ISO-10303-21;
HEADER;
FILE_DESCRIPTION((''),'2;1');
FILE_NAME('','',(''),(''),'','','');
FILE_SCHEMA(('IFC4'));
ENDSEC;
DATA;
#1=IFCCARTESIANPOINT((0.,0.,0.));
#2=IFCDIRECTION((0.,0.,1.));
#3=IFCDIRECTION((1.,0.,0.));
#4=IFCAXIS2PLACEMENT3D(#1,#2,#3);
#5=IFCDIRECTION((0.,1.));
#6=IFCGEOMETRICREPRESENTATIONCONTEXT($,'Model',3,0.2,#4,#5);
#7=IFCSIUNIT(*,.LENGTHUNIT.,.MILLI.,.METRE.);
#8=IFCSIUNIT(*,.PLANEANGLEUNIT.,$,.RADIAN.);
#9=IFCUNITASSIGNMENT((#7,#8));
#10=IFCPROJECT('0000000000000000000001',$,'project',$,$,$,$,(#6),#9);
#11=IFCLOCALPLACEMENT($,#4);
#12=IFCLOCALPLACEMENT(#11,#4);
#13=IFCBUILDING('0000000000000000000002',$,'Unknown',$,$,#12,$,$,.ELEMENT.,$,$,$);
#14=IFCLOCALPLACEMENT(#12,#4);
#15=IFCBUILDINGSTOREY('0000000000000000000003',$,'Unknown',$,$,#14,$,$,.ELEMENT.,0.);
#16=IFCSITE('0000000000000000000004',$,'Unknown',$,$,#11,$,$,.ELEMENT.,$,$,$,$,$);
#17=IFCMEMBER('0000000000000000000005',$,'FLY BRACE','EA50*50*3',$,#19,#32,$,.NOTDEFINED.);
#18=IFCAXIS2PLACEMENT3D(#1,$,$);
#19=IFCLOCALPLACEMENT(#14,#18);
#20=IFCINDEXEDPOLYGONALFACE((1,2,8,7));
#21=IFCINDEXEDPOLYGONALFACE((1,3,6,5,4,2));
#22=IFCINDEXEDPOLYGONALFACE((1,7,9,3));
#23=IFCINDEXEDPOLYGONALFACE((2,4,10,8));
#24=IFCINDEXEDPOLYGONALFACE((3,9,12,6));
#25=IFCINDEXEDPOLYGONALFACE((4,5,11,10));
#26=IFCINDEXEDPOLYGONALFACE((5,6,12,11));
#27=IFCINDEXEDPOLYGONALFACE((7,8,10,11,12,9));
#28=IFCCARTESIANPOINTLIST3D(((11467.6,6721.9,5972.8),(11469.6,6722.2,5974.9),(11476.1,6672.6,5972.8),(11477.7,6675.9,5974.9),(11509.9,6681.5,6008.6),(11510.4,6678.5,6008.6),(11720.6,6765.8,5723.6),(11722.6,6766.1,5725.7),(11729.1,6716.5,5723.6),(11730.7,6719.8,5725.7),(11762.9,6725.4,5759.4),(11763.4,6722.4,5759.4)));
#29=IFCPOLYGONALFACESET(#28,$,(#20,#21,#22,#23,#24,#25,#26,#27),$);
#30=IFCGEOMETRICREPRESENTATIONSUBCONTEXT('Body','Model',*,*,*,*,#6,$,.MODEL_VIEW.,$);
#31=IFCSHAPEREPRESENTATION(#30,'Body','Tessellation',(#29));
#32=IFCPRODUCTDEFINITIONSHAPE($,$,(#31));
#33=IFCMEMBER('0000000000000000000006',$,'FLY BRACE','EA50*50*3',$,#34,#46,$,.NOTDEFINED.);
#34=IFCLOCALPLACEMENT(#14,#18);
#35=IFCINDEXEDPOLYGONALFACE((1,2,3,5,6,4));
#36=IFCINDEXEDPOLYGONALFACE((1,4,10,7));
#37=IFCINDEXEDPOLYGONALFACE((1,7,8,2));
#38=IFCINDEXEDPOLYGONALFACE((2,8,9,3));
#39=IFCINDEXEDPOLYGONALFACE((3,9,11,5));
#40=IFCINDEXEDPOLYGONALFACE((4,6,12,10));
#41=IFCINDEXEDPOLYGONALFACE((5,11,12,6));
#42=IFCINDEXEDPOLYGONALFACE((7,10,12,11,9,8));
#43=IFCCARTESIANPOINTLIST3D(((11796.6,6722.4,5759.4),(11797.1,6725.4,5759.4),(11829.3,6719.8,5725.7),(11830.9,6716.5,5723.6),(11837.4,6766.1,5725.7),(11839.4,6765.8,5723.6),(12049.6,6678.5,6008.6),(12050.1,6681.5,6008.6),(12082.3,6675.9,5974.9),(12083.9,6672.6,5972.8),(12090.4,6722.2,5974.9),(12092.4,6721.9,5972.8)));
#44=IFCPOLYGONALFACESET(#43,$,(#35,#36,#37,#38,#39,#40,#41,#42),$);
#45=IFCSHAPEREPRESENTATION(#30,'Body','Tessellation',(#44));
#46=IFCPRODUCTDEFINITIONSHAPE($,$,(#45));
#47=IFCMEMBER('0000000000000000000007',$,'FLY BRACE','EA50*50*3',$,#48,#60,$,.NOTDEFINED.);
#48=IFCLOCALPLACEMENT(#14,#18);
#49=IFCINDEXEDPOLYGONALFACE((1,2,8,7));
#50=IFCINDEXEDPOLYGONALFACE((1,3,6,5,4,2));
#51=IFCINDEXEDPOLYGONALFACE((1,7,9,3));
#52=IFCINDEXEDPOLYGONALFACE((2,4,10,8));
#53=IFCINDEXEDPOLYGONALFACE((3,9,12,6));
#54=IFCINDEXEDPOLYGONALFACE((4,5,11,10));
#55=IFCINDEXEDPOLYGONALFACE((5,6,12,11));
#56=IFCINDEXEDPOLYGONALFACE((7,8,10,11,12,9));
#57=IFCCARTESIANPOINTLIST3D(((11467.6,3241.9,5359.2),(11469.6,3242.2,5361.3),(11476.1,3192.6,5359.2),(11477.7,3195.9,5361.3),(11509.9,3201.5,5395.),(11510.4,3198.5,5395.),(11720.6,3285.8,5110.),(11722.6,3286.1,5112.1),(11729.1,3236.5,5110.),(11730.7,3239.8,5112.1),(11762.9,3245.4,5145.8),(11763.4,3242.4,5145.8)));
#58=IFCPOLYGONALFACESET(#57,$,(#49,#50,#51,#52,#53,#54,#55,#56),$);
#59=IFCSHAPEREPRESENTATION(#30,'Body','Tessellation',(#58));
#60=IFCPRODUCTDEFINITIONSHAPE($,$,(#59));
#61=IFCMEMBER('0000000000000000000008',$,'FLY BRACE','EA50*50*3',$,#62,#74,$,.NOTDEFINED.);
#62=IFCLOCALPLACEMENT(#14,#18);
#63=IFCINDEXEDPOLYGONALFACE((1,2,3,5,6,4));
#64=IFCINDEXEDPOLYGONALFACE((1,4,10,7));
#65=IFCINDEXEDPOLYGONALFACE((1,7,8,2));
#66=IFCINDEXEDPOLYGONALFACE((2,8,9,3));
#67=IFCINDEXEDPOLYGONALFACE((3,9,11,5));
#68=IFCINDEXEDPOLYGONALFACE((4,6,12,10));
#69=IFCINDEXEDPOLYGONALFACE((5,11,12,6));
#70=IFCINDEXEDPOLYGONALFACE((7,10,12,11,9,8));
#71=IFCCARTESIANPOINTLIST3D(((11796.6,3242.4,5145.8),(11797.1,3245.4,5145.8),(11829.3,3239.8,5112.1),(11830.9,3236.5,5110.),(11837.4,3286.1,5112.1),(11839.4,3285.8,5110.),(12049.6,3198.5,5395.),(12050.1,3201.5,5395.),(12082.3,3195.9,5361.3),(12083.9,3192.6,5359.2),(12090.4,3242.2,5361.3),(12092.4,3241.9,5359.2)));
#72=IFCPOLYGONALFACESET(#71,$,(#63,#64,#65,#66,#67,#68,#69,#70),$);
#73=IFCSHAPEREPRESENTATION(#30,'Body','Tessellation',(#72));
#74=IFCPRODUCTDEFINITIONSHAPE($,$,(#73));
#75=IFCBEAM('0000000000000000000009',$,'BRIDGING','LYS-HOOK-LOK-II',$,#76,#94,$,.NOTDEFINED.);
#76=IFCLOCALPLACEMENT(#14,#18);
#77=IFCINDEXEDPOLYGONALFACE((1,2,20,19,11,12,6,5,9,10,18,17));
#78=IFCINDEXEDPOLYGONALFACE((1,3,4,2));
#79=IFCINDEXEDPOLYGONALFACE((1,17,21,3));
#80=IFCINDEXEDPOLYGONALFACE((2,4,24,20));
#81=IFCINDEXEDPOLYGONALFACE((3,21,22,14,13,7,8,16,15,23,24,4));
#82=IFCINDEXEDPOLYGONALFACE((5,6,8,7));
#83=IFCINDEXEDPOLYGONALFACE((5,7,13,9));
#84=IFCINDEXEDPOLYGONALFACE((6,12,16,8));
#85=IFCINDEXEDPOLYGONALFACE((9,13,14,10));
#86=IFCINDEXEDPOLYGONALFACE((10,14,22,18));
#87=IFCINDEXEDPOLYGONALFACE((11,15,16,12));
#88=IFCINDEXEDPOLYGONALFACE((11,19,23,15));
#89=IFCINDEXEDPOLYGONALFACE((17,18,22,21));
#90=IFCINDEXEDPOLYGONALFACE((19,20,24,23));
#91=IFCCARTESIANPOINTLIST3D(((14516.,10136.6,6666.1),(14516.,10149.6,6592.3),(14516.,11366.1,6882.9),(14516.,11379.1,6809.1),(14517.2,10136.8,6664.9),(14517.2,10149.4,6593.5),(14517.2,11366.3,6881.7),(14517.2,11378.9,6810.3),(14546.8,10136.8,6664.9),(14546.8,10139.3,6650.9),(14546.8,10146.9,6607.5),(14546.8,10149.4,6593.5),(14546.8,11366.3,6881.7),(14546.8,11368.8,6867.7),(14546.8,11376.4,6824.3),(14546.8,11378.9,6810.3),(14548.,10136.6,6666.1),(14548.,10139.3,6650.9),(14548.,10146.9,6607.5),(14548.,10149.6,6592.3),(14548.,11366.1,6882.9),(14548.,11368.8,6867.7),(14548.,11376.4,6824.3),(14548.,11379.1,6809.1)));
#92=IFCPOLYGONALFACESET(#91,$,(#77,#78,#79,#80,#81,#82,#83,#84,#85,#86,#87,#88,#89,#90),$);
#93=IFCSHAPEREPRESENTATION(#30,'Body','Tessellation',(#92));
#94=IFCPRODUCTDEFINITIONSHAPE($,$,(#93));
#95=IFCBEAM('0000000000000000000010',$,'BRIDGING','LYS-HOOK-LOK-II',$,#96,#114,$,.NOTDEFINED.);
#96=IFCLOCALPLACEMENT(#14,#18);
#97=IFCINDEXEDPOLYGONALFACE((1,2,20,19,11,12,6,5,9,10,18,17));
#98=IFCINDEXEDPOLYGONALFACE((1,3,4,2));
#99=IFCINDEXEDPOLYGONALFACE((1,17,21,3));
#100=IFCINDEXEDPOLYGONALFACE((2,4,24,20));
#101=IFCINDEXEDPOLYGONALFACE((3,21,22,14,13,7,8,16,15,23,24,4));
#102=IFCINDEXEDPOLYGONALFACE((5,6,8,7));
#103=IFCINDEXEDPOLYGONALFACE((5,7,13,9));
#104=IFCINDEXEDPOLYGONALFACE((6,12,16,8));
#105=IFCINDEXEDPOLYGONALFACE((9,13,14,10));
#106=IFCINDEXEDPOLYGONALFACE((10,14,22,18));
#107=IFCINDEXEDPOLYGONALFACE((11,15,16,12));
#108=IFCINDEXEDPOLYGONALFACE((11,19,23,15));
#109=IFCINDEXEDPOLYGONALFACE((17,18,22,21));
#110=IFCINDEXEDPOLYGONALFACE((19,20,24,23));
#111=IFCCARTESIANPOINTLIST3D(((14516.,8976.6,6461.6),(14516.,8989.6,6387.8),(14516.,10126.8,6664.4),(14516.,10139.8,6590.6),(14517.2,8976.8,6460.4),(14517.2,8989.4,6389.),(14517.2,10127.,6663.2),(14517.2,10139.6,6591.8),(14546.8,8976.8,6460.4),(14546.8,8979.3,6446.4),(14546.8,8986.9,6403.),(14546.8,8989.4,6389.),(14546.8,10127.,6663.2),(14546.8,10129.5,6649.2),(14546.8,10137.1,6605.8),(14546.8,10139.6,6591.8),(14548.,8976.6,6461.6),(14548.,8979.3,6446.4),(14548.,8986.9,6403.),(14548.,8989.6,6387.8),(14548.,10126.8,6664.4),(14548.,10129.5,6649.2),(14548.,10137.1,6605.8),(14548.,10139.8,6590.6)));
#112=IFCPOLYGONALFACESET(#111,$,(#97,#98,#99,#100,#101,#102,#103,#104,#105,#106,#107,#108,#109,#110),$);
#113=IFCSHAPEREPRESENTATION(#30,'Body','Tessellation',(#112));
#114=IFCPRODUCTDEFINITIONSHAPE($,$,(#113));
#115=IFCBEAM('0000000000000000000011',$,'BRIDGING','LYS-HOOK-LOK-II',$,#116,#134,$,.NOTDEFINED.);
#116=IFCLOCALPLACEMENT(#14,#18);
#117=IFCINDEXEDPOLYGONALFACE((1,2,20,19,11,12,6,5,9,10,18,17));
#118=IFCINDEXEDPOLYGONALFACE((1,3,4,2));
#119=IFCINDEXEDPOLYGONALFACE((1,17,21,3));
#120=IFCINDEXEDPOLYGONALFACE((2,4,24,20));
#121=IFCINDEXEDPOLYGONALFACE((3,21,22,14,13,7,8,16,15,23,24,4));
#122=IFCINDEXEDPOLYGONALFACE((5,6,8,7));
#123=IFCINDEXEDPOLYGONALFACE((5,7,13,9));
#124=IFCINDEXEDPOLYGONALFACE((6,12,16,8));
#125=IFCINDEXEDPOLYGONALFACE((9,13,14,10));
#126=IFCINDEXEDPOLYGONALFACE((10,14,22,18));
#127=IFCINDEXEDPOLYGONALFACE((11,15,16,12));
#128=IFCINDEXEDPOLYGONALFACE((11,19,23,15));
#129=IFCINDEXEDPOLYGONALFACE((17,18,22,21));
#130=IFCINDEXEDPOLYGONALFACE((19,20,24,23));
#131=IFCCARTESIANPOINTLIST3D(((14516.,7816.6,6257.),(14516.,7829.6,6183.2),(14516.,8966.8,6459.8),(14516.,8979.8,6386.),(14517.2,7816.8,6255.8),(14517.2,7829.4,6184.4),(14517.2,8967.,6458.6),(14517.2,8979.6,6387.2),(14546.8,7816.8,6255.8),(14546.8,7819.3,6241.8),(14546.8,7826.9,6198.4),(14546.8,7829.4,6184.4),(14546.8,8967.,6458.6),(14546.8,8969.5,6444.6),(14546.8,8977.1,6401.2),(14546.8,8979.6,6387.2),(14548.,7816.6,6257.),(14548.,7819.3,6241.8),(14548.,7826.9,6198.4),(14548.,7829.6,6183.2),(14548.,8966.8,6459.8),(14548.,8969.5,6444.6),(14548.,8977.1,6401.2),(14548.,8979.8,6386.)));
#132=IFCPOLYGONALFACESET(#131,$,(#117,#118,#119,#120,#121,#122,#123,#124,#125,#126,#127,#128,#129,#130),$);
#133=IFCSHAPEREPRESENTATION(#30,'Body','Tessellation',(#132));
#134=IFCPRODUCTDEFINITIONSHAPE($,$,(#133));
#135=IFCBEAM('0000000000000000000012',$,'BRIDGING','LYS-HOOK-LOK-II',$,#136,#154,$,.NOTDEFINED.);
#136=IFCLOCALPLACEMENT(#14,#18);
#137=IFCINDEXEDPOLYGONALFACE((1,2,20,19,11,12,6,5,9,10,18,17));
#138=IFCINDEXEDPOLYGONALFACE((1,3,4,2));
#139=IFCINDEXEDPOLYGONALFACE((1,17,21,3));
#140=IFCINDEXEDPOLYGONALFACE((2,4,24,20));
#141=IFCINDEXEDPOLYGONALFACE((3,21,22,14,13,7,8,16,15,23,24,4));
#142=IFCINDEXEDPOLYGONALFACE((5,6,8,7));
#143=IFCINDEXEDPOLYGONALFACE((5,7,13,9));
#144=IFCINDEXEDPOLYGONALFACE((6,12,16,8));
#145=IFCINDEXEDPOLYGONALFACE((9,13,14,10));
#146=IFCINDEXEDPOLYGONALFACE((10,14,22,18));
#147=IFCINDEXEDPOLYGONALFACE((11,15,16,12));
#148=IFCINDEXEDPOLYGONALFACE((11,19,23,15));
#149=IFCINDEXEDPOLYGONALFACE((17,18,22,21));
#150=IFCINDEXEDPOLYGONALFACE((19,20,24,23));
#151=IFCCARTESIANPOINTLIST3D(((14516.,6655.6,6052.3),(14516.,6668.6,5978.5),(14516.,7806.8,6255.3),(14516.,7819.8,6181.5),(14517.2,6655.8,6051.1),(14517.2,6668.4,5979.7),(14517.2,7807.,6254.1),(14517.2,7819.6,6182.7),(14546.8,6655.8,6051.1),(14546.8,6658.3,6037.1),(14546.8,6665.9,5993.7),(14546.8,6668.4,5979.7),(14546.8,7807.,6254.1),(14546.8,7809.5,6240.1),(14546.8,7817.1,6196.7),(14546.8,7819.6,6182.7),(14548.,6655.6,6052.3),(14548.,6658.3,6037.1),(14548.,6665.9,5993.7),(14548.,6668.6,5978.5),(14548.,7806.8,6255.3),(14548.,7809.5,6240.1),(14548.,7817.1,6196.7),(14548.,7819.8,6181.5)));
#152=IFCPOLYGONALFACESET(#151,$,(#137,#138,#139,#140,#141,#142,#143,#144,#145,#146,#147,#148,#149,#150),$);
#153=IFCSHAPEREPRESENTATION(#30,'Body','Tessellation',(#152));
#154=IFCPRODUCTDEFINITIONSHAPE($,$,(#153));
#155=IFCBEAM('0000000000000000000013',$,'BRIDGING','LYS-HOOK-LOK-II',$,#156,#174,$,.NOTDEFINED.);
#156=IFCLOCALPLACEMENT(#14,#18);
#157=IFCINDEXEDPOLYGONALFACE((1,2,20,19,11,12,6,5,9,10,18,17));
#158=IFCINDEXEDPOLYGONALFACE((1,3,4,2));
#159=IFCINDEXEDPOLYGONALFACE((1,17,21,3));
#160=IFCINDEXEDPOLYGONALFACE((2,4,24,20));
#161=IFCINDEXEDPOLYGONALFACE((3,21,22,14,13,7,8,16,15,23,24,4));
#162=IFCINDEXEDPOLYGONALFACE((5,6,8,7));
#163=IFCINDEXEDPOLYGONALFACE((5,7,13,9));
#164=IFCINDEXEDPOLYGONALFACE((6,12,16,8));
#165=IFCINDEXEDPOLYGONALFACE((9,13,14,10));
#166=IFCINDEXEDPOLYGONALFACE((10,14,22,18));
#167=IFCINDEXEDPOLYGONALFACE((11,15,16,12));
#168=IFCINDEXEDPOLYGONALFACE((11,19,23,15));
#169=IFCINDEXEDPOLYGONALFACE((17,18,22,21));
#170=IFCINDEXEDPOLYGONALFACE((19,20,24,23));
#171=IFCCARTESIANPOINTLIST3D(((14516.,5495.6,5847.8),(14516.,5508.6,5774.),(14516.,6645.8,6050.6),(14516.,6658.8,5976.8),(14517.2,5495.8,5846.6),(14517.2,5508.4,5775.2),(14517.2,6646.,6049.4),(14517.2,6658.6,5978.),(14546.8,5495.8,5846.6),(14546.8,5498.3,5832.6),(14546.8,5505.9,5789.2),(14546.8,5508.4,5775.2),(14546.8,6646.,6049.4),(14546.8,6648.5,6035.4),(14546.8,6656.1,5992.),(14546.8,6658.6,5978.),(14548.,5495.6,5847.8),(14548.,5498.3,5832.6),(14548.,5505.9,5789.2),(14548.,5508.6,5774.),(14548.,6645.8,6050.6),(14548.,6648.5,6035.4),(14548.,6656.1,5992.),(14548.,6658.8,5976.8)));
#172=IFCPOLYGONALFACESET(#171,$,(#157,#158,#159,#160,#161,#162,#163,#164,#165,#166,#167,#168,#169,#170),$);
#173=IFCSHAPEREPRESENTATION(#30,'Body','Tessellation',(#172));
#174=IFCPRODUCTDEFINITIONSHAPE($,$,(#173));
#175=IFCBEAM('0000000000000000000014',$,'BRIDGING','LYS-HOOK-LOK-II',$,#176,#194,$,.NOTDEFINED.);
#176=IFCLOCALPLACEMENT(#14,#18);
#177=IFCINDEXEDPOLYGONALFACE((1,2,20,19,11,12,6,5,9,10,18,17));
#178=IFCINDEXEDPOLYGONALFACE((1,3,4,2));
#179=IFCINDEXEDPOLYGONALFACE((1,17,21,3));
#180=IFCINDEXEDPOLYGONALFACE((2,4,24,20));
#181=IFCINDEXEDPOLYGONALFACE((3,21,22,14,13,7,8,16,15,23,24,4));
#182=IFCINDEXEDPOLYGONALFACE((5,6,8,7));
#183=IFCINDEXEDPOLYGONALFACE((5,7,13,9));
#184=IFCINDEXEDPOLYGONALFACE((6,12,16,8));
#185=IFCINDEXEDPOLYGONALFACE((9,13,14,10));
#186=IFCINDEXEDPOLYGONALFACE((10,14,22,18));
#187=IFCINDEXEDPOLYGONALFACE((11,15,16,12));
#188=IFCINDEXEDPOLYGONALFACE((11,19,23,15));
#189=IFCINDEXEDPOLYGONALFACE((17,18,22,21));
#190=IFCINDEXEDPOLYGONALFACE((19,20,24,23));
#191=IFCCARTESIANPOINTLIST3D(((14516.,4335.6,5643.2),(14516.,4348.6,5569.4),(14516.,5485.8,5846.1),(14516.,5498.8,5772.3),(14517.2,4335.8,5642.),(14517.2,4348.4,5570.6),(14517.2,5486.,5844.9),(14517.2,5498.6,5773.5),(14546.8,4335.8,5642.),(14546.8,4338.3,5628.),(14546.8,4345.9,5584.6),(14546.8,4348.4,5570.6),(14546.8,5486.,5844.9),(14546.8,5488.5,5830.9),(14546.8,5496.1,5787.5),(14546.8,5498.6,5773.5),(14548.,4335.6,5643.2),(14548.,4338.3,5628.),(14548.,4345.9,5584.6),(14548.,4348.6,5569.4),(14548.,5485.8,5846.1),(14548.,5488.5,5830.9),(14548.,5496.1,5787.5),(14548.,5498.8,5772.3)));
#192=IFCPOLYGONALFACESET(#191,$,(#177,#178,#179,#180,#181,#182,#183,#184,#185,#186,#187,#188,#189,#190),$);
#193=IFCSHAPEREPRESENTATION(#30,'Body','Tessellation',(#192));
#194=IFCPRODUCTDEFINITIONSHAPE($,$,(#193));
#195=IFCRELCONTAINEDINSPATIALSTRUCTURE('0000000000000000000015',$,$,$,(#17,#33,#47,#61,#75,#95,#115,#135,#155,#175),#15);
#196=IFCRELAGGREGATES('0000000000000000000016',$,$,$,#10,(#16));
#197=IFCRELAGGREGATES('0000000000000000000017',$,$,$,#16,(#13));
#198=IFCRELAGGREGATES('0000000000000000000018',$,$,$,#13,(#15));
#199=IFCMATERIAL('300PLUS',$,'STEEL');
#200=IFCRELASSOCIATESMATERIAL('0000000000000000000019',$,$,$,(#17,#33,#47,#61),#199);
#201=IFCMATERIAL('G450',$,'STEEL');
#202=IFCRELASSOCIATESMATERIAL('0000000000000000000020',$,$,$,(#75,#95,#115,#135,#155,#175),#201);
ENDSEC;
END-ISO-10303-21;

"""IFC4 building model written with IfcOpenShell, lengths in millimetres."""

from ifc_helpers import new_model, si_unit, direction, frame, origin_with_axes, place, context, subcontext, project, spatial, line, indexed_curve, outline, extrude, material, element, save


model = new_model("IFC4")

# Units and contexts
model_context = context("Model", 3, precision=0.2, world=origin_with_axes(), true_north=direction((0.0, 1.0)))
body_context = subcontext(model_context, "Body", "Model", "MODEL_VIEW")
ifc_project = project(units=[si_unit("LENGTHUNIT", "METRE", prefix="MILLI"), si_unit("PLANEANGLEUNIT", "RADIAN")], contexts=[model_context])

# Site, building, storey
site_placement = place(None, origin_with_axes())
site = spatial("IfcSite", under=ifc_project, at=site_placement, Name="Unknown", CompositionType="ELEMENT")
building_placement = place(site_placement, origin_with_axes())
building = spatial("IfcBuilding", under=site, at=building_placement, Name="Unknown", CompositionType="ELEMENT")
storey_placement = place(building_placement, origin_with_axes())
storey = spatial("IfcBuildingStorey", under=building, at=storey_placement, Name="Unknown", CompositionType="ELEMENT", Elevation=0.0)

# Members
ifc_material_1 = material(Name="300PLUS", Category="STEEL")
for number, where, z_axis, x_axis, name in (
    (1, (11489.0, 6700.2, 5990.7), (0.686182, 0.119065, 0.71762), (0.707055, 0.122687, -0.696435), "FLY BRACE"),
    (2, (12071.0, 6700.2, 5990.7), (0.170963, 0.985277, 0.0), (-0.707055, 0.122687, -0.696435), "FLY BRACE"),
    (3, (11489.0, 3220.2, 5377.1), (0.686182, 0.119065, 0.71762), (0.707055, 0.122687, -0.696435), "FLY BRACE"),
    (4, (12071.0, 3220.2, 5377.1), (0.170963, 0.985277, 0.0), (-0.707055, 0.122687, -0.696435), "FLY BRACE"),
):
    element("IfcMember", number, at=place(storey_placement, frame(where, z_axis=z_axis, x_axis=x_axis)), inside=storey, material=ifc_material_1, Name=name, Description="EA50*50*3", PredefinedType="NOTDEFINED", context=body_context, shape_type="SolidModel", body=[
        extrude(outline(indexed_curve([(-25.0, -25.0), (25.0, -25.0), (25.0, -22.0), (-22.0, -22.0), (-22.0, 25.0), (-25.0, 25.0)], segments=[line(1, 2, 3, 4, 5, 6, 1)])), frame((0.0, 0.0, 0.0), z_axis=(-1.0, 0.0, 0.0), x_axis=(0.0, 0.0, 1.0)), (0.0, 0.0, -1.0), 357.8),
    ])

# Beams
ifc_material_2 = material(Name="G450", Category="STEEL")
beam_1_placement = place(storey_placement, frame((14532.0, 10143.1, 6629.2), z_axis=(1.0, 0.0, 0.0), x_axis=(0.0, 0.984807, 0.173653)))
element("IfcBeam", 5, at=beam_1_placement, inside=storey, material=ifc_material_2, Name="BRIDGING", Description="LYS-HOOK-LOK-II", PredefinedType="NOTDEFINED", context=body_context, shape_type="SolidModel", body=[
    extrude(outline(indexed_curve([(16.0, -37.5), (16.0, -22.0), (14.8, -22.0), (14.8, -36.3), (-14.8, -36.3), (-14.8, 36.3), (14.8, 36.3), (14.8, 22.0), (16.0, 22.0), (16.0, 37.5), (-16.0, 37.5), (-16.0, -37.5)], segments=[line(1, 2, 3, 4, 5, 6, 7, 8, 9, 10, 11, 12, 1)])), frame((0.0, 0.0, 0.0), z_axis=(-1.0, 0.0, 0.0), x_axis=(0.0, 0.0, 1.0)), (0.0, 0.0, -1.0), 1248.5),
])
for number, where, z_axis, x_axis, name in (
    (6, (14532.0, 8983.1, 6424.7), (1.0, 0.0, 0.0), (0.0, 0.984809, 0.173639), "BRIDGING"),
    (7, (14532.0, 7823.1, 6220.1), (1.0, 0.0, 0.0), (0.0, 0.984809, 0.173639), "BRIDGING"),
):
    element("IfcBeam", number, at=place(storey_placement, frame(where, z_axis=z_axis, x_axis=x_axis)), inside=storey, material=ifc_material_2, Name=name, Description="LYS-HOOK-LOK-II", PredefinedType="NOTDEFINED", context=body_context, shape_type="SolidModel", body=[
        extrude(outline(indexed_curve([(16.0, -37.5), (16.0, -22.0), (14.8, -22.0), (14.8, -36.3), (-14.8, -36.3), (-14.8, 36.3), (14.8, 36.3), (14.8, 22.0), (16.0, 22.0), (16.0, 37.5), (-16.0, 37.5), (-16.0, -37.5)], segments=[line(1, 2, 3, 4, 5, 6, 7, 8, 9, 10, 11, 12, 1)])), frame((0.0, 0.0, 0.0), z_axis=(-1.0, 0.0, 0.0), x_axis=(0.0, 0.0, 1.0)), (0.0, 0.0, -1.0), 1167.9),
    ])
beam_2_placement = place(storey_placement, frame((14532.0, 6662.1, 6015.4), z_axis=(1.0, 0.0, 0.0), x_axis=(0.0, 0.984806, 0.173658)))
element("IfcBeam", 8, at=beam_2_placement, inside=storey, material=ifc_material_2, Name="BRIDGING", Description="LYS-HOOK-LOK-II", PredefinedType="NOTDEFINED", context=body_context, shape_type="SolidModel", body=[
    extrude(outline(indexed_curve([(16.0, -37.5), (16.0, -22.0), (14.8, -22.0), (14.8, -36.3), (-14.8, -36.3), (-14.8, 36.3), (14.8, 36.3), (14.8, 22.0), (16.0, 22.0), (16.0, 37.5), (-16.0, 37.5), (-16.0, -37.5)], segments=[line(1, 2, 3, 4, 5, 6, 7, 8, 9, 10, 11, 12, 1)])), frame((0.0, 0.0, 0.0), z_axis=(-1.0, 0.0, 0.0), x_axis=(0.0, 0.0, 1.0)), (0.0, 0.0, -1.0), 1169.0),
])
beam_3_placement = place(storey_placement, frame((14532.0, 5502.1, 5810.9), z_axis=(1.0, 0.0, 0.0), x_axis=(0.0, 0.984809, 0.173639)))
element("IfcBeam", 9, at=beam_3_placement, inside=storey, material=ifc_material_2, Name="BRIDGING", Description="LYS-HOOK-LOK-II", PredefinedType="NOTDEFINED", context=body_context, shape_type="SolidModel", body=[
    extrude(outline(indexed_curve([(16.0, -37.5), (16.0, -22.0), (14.8, -22.0), (14.8, -36.3), (-14.8, -36.3), (-14.8, 36.3), (14.8, 36.3), (14.8, 22.0), (16.0, 22.0), (16.0, 37.5), (-16.0, 37.5), (-16.0, -37.5)], segments=[line(1, 2, 3, 4, 5, 6, 7, 8, 9, 10, 11, 12, 1)])), frame((0.0, 0.0, 0.0), z_axis=(-1.0, 0.0, 0.0), x_axis=(0.0, 0.0, 1.0)), (0.0, 0.0, -1.0), 1167.9),
])
beam_4_placement = place(storey_placement, frame((14532.0, 4342.1, 5606.3), z_axis=(1.0, 0.0, 0.0), x_axis=(0.0, 0.984795, 0.173722)))
element("IfcBeam", 10, at=beam_4_placement, inside=storey, material=ifc_material_2, Name="BRIDGING", Description="LYS-HOOK-LOK-II", PredefinedType="NOTDEFINED", context=body_context, shape_type="SolidModel", body=[
    extrude(outline(indexed_curve([(16.0, -37.5), (16.0, -22.0), (14.8, -22.0), (14.8, -36.3), (-14.8, -36.3), (-14.8, 36.3), (14.8, 36.3), (14.8, 22.0), (16.0, 22.0), (16.0, 37.5), (-16.0, 37.5), (-16.0, -37.5)], segments=[line(1, 2, 3, 4, 5, 6, 7, 8, 9, 10, 11, 12, 1)])), frame((0.0, 0.0, 0.0), z_axis=(-1.0, 0.0, 0.0), x_axis=(0.0, 0.0, 1.0)), (0.0, 0.0, -1.0), 1168.0),
])

save(model, "model.ifc")
